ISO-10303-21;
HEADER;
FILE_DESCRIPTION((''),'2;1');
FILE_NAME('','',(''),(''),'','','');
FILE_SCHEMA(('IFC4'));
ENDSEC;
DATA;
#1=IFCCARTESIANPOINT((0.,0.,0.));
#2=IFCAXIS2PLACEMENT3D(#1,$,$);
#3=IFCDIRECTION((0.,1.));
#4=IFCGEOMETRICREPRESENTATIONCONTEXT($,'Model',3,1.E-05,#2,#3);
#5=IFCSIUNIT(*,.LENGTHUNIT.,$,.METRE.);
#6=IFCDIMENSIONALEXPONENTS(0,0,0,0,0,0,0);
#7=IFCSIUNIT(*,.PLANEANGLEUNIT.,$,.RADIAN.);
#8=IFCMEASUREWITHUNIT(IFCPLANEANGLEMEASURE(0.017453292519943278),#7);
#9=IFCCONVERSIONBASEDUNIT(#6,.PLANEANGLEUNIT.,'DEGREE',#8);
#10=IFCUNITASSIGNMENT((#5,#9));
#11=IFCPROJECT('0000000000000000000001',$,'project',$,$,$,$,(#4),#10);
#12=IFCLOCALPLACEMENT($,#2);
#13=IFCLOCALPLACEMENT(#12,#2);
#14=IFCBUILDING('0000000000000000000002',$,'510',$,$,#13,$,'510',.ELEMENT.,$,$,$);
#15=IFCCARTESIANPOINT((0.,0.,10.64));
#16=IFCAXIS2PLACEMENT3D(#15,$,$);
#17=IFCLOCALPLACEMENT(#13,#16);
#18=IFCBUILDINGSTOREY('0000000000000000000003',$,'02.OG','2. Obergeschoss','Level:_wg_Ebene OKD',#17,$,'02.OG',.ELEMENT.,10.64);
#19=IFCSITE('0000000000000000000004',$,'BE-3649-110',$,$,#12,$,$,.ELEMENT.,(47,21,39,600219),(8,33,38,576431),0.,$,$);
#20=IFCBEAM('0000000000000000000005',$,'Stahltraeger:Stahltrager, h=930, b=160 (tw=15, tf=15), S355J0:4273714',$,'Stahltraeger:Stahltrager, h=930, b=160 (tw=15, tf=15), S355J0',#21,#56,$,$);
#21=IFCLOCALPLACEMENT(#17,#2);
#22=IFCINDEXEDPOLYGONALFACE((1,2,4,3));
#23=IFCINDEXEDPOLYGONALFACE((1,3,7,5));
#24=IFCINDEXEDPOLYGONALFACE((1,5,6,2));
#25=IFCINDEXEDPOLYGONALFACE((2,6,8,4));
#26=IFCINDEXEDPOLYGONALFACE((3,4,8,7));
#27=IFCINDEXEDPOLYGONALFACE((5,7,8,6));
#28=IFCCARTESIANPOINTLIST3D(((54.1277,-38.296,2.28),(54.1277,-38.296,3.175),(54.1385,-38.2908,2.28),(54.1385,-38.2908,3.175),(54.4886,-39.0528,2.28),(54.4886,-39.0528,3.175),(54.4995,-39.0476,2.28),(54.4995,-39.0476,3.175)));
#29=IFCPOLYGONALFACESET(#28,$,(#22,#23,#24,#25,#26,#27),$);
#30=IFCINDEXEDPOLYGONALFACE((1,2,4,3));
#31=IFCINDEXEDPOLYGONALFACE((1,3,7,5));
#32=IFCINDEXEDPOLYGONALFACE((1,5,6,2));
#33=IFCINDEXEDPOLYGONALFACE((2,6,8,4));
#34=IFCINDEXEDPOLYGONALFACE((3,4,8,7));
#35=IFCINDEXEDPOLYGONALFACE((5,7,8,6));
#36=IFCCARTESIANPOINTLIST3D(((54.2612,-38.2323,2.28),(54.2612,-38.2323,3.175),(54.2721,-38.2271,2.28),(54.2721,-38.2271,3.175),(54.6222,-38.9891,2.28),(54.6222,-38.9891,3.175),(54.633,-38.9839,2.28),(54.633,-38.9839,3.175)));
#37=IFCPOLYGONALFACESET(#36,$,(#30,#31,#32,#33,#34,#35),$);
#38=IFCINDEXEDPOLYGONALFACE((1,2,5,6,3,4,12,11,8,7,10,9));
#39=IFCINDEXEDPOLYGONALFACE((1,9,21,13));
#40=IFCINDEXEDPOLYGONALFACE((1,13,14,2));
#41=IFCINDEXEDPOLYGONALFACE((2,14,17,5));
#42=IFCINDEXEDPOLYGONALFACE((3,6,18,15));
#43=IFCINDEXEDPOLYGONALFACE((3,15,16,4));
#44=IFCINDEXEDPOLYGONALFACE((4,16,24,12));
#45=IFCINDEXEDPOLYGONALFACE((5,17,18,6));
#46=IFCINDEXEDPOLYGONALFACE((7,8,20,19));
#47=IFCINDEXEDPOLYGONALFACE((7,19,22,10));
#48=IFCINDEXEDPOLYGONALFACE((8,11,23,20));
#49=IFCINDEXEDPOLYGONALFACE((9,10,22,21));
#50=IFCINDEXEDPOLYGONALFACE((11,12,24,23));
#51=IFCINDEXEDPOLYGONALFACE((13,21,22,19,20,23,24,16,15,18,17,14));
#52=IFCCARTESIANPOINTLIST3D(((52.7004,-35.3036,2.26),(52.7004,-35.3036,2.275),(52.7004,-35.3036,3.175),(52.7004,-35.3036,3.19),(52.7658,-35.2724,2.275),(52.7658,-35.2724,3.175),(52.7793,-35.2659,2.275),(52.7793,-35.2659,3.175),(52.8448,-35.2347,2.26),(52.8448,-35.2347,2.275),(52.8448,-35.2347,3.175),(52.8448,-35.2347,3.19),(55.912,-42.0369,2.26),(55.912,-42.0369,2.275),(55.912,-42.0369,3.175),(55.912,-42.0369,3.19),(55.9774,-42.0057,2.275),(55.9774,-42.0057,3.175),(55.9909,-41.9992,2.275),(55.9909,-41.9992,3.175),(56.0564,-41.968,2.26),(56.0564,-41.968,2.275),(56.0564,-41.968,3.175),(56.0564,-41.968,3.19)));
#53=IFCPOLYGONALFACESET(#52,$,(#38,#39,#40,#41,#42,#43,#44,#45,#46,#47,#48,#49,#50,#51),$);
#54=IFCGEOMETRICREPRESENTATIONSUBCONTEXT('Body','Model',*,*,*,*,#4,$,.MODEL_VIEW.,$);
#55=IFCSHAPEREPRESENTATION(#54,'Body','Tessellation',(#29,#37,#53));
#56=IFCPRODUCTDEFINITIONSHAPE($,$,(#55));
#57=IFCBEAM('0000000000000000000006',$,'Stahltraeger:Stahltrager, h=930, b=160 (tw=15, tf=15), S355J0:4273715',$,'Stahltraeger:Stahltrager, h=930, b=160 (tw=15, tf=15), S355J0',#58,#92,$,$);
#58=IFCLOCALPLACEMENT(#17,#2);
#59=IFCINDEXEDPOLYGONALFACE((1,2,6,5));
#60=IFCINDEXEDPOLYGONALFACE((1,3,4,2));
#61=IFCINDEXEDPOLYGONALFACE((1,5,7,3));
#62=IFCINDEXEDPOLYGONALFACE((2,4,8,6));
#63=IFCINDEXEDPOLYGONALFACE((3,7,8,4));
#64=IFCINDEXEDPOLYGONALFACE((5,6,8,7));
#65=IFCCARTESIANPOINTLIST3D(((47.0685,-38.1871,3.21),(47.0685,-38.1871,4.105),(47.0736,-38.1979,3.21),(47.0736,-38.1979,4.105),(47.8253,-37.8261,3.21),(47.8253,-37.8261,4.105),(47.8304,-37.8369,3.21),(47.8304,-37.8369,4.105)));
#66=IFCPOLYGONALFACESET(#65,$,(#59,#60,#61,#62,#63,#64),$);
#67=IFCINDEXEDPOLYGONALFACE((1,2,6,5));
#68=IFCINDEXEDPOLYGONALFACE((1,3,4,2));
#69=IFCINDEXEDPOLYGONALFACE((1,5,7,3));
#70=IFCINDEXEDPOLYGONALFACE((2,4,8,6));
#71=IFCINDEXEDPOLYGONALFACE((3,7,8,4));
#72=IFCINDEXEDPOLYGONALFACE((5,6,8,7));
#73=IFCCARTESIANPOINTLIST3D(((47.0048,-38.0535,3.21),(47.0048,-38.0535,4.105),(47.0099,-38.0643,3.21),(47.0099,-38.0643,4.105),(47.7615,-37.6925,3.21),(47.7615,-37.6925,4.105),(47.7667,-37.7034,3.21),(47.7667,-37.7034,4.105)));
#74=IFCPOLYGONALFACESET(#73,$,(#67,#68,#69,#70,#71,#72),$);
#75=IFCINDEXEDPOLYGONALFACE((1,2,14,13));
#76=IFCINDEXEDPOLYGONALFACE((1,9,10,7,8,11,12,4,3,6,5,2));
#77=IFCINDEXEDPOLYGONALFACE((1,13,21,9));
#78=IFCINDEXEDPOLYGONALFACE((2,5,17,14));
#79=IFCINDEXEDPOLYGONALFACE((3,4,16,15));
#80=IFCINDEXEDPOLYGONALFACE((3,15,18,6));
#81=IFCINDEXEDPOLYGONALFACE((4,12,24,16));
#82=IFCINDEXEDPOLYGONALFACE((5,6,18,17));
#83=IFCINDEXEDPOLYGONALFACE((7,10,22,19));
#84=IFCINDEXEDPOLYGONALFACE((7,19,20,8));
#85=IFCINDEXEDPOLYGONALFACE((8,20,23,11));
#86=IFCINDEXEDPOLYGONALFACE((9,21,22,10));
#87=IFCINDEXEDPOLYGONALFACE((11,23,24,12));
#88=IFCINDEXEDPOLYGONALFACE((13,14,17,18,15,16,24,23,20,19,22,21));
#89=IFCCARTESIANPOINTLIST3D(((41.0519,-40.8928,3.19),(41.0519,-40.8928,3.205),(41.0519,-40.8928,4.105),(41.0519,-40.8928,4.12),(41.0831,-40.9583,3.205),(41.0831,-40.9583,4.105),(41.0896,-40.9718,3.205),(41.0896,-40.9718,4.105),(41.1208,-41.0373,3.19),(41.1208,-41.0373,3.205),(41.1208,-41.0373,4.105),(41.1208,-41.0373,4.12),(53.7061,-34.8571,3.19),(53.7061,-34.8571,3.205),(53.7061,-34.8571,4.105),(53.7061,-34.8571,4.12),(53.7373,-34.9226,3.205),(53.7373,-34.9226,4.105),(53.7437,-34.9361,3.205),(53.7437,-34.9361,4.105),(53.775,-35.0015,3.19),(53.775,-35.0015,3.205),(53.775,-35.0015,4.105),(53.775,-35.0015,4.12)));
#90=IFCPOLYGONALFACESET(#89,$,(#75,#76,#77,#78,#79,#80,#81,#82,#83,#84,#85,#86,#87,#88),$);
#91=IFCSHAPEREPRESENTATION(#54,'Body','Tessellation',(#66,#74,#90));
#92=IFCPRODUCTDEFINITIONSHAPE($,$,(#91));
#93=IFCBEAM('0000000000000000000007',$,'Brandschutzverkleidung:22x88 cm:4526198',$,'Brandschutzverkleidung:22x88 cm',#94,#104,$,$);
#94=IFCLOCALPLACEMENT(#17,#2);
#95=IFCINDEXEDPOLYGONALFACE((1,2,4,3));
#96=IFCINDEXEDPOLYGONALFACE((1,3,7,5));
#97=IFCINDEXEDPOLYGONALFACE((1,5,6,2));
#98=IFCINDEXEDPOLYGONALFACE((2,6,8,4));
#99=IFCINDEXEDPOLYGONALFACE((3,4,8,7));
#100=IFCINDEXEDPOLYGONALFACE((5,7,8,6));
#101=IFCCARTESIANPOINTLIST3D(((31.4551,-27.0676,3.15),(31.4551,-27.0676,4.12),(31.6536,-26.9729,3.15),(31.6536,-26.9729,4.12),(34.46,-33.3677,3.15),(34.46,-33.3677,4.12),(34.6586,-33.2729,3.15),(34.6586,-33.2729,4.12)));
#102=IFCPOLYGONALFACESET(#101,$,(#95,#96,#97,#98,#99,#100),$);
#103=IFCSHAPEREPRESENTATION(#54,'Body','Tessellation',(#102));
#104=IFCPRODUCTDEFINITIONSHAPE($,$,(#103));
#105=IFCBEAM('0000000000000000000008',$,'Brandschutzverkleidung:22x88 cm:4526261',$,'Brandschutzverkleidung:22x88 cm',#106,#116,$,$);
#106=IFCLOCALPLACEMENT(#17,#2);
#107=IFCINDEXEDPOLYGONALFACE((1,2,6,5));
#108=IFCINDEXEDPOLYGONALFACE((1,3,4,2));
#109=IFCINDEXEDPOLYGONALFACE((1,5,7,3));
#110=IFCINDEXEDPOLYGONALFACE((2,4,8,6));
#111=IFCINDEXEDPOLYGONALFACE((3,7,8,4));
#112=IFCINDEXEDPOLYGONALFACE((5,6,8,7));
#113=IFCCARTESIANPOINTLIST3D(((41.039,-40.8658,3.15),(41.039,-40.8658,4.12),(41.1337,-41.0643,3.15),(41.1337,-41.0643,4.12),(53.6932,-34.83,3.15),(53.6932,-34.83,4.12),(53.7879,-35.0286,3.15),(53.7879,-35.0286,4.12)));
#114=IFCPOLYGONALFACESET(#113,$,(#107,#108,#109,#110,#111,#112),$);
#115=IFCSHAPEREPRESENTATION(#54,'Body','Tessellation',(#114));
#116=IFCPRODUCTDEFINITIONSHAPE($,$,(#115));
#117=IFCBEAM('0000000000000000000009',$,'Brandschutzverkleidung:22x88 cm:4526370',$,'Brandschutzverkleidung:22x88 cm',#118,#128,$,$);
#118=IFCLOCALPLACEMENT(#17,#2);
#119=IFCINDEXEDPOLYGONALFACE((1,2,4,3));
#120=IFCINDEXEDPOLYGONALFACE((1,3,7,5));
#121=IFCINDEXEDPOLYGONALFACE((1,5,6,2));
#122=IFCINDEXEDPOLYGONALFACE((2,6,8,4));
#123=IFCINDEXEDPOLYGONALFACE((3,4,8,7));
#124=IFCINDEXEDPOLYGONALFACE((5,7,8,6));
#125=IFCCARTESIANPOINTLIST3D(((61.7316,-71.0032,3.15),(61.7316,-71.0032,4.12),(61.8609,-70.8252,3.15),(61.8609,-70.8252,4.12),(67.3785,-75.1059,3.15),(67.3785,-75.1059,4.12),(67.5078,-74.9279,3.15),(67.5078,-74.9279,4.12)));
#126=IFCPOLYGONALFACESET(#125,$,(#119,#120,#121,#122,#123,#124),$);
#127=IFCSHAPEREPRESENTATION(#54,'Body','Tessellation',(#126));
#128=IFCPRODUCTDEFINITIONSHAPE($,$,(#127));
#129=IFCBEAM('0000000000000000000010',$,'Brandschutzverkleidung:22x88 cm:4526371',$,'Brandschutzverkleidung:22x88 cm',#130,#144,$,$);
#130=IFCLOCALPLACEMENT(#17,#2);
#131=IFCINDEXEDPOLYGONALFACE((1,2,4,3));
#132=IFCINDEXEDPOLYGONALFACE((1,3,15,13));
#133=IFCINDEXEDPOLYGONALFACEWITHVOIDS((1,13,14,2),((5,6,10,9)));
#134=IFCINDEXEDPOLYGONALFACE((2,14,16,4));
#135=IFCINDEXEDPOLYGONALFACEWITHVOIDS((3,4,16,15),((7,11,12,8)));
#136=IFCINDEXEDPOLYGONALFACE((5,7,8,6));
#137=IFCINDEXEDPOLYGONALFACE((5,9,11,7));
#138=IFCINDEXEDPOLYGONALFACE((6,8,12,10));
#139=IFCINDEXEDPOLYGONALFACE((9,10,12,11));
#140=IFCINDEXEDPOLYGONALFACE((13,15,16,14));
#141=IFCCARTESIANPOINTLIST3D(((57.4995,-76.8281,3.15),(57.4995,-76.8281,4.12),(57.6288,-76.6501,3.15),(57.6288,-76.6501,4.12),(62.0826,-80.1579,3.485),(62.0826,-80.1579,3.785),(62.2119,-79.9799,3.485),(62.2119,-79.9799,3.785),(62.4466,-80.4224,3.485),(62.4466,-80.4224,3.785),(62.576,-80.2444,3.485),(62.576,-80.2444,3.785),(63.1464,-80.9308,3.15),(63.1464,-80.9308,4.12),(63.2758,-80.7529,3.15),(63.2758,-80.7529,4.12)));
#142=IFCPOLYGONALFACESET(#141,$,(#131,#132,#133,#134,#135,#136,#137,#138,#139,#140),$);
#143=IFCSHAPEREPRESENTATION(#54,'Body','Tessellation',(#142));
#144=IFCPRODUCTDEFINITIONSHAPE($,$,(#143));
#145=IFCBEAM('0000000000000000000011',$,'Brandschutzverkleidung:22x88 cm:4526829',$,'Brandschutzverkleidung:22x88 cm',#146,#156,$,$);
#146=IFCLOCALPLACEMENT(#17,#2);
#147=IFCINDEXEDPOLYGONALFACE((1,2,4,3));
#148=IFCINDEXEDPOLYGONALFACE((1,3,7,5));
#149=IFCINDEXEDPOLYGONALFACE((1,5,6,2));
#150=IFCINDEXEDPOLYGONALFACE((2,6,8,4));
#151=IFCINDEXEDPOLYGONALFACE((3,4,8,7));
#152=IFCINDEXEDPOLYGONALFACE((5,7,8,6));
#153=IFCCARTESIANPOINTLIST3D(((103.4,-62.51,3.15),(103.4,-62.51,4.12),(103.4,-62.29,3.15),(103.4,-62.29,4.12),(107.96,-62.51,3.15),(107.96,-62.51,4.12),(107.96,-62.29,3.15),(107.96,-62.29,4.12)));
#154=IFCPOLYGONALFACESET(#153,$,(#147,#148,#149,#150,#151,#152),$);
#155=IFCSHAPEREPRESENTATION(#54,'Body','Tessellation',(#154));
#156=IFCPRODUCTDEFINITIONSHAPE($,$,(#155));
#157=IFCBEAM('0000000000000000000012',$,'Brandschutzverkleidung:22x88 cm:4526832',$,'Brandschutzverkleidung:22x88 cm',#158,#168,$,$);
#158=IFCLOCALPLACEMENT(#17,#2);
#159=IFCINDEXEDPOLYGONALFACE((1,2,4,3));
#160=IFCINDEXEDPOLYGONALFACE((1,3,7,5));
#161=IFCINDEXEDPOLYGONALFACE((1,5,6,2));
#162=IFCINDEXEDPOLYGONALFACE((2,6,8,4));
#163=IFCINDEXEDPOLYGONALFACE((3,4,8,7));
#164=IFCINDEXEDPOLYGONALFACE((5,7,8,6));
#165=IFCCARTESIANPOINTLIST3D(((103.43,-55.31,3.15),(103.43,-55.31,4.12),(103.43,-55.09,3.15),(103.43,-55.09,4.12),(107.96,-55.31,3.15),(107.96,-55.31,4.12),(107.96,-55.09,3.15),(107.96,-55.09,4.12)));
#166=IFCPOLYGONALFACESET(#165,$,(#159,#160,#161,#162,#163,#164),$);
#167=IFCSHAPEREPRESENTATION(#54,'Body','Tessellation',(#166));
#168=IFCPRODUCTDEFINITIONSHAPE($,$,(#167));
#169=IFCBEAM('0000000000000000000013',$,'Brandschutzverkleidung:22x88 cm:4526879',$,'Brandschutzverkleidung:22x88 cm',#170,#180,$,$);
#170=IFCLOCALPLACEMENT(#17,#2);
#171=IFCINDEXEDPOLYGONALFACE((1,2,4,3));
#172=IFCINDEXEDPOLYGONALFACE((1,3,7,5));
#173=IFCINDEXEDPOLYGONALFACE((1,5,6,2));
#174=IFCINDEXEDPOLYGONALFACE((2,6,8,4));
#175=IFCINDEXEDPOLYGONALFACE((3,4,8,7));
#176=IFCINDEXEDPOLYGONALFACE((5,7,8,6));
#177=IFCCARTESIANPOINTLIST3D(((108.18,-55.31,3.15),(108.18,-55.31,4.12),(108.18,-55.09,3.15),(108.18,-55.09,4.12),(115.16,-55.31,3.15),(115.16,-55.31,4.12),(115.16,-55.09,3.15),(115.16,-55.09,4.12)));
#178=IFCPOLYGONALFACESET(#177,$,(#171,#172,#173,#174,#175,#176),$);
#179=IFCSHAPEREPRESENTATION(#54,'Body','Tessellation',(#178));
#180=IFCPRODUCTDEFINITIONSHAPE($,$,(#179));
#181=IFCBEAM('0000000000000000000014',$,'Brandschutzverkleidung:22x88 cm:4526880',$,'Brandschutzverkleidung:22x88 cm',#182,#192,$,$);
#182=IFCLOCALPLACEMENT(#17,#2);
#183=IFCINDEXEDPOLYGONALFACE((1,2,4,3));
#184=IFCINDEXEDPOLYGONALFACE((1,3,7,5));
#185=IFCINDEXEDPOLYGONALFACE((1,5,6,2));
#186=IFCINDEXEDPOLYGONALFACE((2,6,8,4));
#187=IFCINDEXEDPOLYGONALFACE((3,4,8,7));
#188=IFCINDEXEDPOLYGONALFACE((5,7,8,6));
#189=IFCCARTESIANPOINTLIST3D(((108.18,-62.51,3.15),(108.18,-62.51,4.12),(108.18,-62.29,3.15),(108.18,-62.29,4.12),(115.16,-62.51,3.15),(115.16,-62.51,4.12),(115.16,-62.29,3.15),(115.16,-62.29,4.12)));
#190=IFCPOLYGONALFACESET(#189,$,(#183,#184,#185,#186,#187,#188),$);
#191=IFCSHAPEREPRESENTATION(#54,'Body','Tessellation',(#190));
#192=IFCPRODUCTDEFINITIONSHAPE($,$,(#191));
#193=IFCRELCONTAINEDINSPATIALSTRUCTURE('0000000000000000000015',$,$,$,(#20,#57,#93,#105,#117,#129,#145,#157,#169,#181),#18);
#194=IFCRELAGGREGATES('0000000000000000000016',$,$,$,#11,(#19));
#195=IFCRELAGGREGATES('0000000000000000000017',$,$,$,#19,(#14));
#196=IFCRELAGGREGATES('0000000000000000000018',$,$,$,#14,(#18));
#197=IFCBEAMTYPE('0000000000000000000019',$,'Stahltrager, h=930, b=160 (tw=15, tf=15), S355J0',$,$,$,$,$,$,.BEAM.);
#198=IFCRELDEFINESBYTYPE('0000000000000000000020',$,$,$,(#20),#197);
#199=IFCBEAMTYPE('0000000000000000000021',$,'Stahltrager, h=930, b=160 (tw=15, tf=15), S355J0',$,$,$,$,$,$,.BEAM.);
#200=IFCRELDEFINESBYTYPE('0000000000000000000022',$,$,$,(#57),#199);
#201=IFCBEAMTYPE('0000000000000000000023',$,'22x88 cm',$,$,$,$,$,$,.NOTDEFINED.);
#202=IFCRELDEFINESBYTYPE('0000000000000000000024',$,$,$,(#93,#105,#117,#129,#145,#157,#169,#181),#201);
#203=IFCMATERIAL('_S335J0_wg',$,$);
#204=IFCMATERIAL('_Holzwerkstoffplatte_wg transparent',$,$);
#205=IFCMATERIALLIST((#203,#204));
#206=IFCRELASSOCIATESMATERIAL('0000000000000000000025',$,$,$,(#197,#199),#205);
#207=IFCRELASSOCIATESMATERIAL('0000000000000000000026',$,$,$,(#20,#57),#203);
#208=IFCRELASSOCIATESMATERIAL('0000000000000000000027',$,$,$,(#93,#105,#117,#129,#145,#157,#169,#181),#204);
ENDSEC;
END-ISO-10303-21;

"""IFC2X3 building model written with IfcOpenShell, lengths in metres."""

from ifc_helpers import new_model, entity, si_unit, converted_unit, direction, frame, frame_2d, origin, origin_2d_with_axis, place, context, subcontext, project, spatial, polyline, rectangle, i_section, outline, extrude, source, transform, mapped, material, material_list, type_object, type_shapes, element, save


model = new_model("IFC2X3")

# Units and contexts
model_context = context("Model", 3, precision=1e-05, world=origin(), true_north=direction((0.0, 1.0)))
body_context = subcontext(model_context, "Body", "Model", "MODEL_VIEW")
ifc_project = project(units=[si_unit("LENGTHUNIT", "METRE"), converted_unit("PLANEANGLEUNIT", "DEGREE", entity("IfcPlaneAngleMeasure", 0.017453292519943278), si_unit("PLANEANGLEUNIT", "RADIAN"), dimensions=[0, 0, 0, 0, 0, 0, 0])], contexts=[model_context])

# Site, building, storey
site_placement = place(None, origin())
site = spatial("IfcSite", under=ifc_project, at=site_placement, Name="BE-3649-110", CompositionType="ELEMENT", RefLatitude=(47, 21, 39, 600219), RefLongitude=(8, 33, 38, 576431), RefElevation=0.0)
building_placement = place(site_placement, origin())
building = spatial("IfcBuilding", under=site, at=building_placement, Name="510", LongName="510", CompositionType="ELEMENT")
storey_placement = place(building_placement, frame((0.0, 0.0, 10.64)))
storey = spatial("IfcBuildingStorey", under=building, at=storey_placement, Name="02.OG", Description="2. Obergeschoss", ObjectType="Level:_wg_Ebene OKD", LongName="02.OG", CompositionType="ELEMENT", Elevation=10.64)

# Beams
ifc_material_1 = material(Name="_S335J0_wg")
ifc_material_2 = material(Name="_Holzwerkstoffplatte_wg transparent")
ifc_material_list = material_list([ifc_material_1, ifc_material_2])
beam_type_1 = type_object("IfcBeamType", Name="Stahltrager, h=930, b=160 (tw=15, tf=15), S355J0", PredefinedType="BEAM", material=ifc_material_list)
shared_shape_1 = source(origin(), body_context, "Body", "SweptSolid", [
    extrude(rectangle(XDim=0.895, YDim=0.012, at=frame_2d((0.0, 0.0), x_axis=(1.0, 0.0))), frame((54.1331, -38.2934, 13.3675), z_axis=(0.430511, -0.902585, 0.0), x_axis=(0.0, 0.0, -1.0)), (0.0, 0.0, 1.0), 0.8385),
    extrude(rectangle(XDim=0.895, YDim=0.012, at=frame_2d((0.0, 0.0), x_axis=(1.0, 0.0))), frame((54.2667, -38.2297, 13.3675), z_axis=(0.430511, -0.902585, 0.0), x_axis=(0.0, 0.0, -1.0)), (0.0, 0.0, 1.0), 0.8385),
    extrude(i_section(OverallWidth=0.16, OverallDepth=0.93, WebThickness=0.015, FlangeThickness=0.015, at=frame_2d((0.0, 0.0), x_axis=(0.0, 1.0))), frame((52.7726, -35.2691, 13.365), z_axis=(0.430511, -0.902585, 0.0), x_axis=(0.0, 0.0, -1.0)), (0.0, 0.0, 1.0), 7.46),
])
type_shapes(beam_type_1, [shared_shape_1])
beam_1_placement = place(storey_placement, frame((0.0, 0.0, -10.64)))
element("IfcBeam", 1, at=beam_1_placement, inside=storey, type_object=beam_type_1, material=ifc_material_1, Name="Stahltraeger:Stahltrager, h=930, b=160 (tw=15, tf=15), S355J0:4273714", ObjectType="Stahltraeger:Stahltrager, h=930, b=160 (tw=15, tf=15), S355J0", context=body_context, shape_type="MappedRepresentation", body=[
    mapped(shared_shape_1, transform((0.0, 0.0, 0.0), scale=1.0)),
])
beam_type_2 = type_object("IfcBeamType", Name="Stahltrager, h=930, b=160 (tw=15, tf=15), S355J0", PredefinedType="BEAM", material=ifc_material_list)
shared_shape_2 = source(origin(), body_context, "Body", "SweptSolid", [
    extrude(rectangle(XDim=0.895, YDim=0.012, at=frame_2d((0.0, 0.0), x_axis=(1.0, 0.0))), frame((47.0711, -38.1925, 14.2975), z_axis=(0.902585, 0.430511, 0.0), x_axis=(0.0, 0.0, 1.0)), (0.0, 0.0, 1.0), 0.8385),
    extrude(rectangle(XDim=0.895, YDim=0.012, at=frame_2d((0.0, 0.0), x_axis=(1.0, 0.0))), frame((47.0073, -38.0589, 14.2975), z_axis=(0.902585, 0.430511, 0.0), x_axis=(0.0, 0.0, 1.0)), (0.0, 0.0, 1.0), 0.8385),
    extrude(outline(polyline([(0.45, -0.08), (0.465, -0.08), (0.465, 0.08), (0.45, 0.08), (0.45, 0.0075), (-0.45, 0.0075), (-0.45, 0.08), (-0.465, 0.08), (-0.465, -0.08), (-0.45, -0.08), (-0.45, -0.0075), (0.45, -0.0075), (0.45, -0.08)])), frame((41.0864, -40.9651, 14.295), z_axis=(0.902585, 0.430511, 0.0), x_axis=(0.0, 0.0, 1.0)), (0.0, 0.0, 1.0), 14.0199),
])
type_shapes(beam_type_2, [shared_shape_2])
beam_2_placement = place(storey_placement, frame((0.0, 0.0, -10.64)))
element("IfcBeam", 2, at=beam_2_placement, inside=storey, type_object=beam_type_2, material=ifc_material_1, Name="Stahltraeger:Stahltrager, h=930, b=160 (tw=15, tf=15), S355J0:4273715", ObjectType="Stahltraeger:Stahltrager, h=930, b=160 (tw=15, tf=15), S355J0", context=body_context, shape_type="MappedRepresentation", body=[
    mapped(shared_shape_2, transform((0.0, 0.0, 0.0), scale=1.0)),
])
beam_type_3 = type_object("IfcBeamType", Name="22x88 cm", PredefinedType="NOTDEFINED")
beam_3_placement = place(storey_placement, frame((0.0, 0.0, 3.635)))
element("IfcBeam", 3, at=beam_3_placement, inside=storey, type_object=beam_type_3, material=ifc_material_2, Name="Brandschutzverkleidung:22x88 cm:4526198", ObjectType="Brandschutzverkleidung:22x88 cm", context=body_context, shape_type="SweptSolid", body=[
    extrude(rectangle(XDim=0.97, YDim=0.22, at=frame_2d((0.0, 0.0), x_axis=(0.0, 1.0))), frame((34.5593, -33.3203, 0.0), z_axis=(-0.430511, 0.902585, 0.0), x_axis=(0.902585, 0.430511, 0.0)), (0.0, 0.0, 1.0), 6.98),
])
beam_4_placement = place(storey_placement, frame((0.0, 0.0, 3.635)))
element("IfcBeam", 4, at=beam_4_placement, inside=storey, type_object=beam_type_3, material=ifc_material_2, Name="Brandschutzverkleidung:22x88 cm:4526261", ObjectType="Brandschutzverkleidung:22x88 cm", context=body_context, shape_type="SweptSolid", body=[
    extrude(rectangle(XDim=0.97, YDim=0.22, at=origin_2d_with_axis()), frame((41.0864, -40.9651, 0.0), z_axis=(0.902585, 0.430511, 0.0), x_axis=(0.0, 0.0, -1.0)), (0.0, 0.0, 1.0), 14.0199),
])
beam_5_placement = place(storey_placement, frame((0.0, 0.0, 3.635)))
element("IfcBeam", 5, at=beam_5_placement, inside=storey, type_object=beam_type_3, material=ifc_material_2, Name="Brandschutzverkleidung:22x88 cm:4526370", ObjectType="Brandschutzverkleidung:22x88 cm", context=body_context, shape_type="SweptSolid", body=[
    extrude(rectangle(XDim=0.97, YDim=0.22, at=frame_2d((0.0, 0.0), x_axis=(1.0, 0.0))), frame((61.7962, -70.9142, 0.0), z_axis=(0.809017, -0.587785, 0.0), x_axis=(0.0, 0.0, -1.0)), (0.0, 0.0, 1.0), 6.98),
])
beam_6_placement = place(storey_placement, frame((0.0, 0.0, 3.635)))
element("IfcBeam", 6, at=beam_6_placement, inside=storey, type_object=beam_type_3, material=ifc_material_2, Name="Brandschutzverkleidung:22x88 cm:4526371", ObjectType="Brandschutzverkleidung:22x88 cm", context=body_context, shape_type="SweptSolid", body=[
    extrude(outline(polyline([(-3.49, -0.485), (3.49, -0.485), (3.49, 0.485), (-3.49, 0.485), (-3.49, -0.485)]), holes=[polyline([(2.175, -0.15), (2.175, 0.15), (2.625, 0.15), (2.625, -0.15), (2.175, -0.15)])]), frame((60.323, -78.8795, 0.0), z_axis=(0.587785, 0.809017, 0.0), x_axis=(0.809017, -0.587785, 0.0)), (0.0, 0.0, 1.0), 0.22),
])
beam_7_placement = place(storey_placement, frame((0.0, 0.0, 3.635)))
element("IfcBeam", 7, at=beam_7_placement, inside=storey, type_object=beam_type_3, material=ifc_material_2, Name="Brandschutzverkleidung:22x88 cm:4526829", ObjectType="Brandschutzverkleidung:22x88 cm", context=body_context, shape_type="SweptSolid", body=[
    extrude(rectangle(XDim=0.97, YDim=0.22, at=origin_2d_with_axis()), frame((103.4, -62.4, 0.0), z_axis=(1.0, 0.0, 0.0), x_axis=(0.0, 0.0, -1.0)), (0.0, 0.0, 1.0), 4.56),
])
beam_8_placement = place(storey_placement, frame((0.0, 0.0, 3.635)))
element("IfcBeam", 8, at=beam_8_placement, inside=storey, type_object=beam_type_3, material=ifc_material_2, Name="Brandschutzverkleidung:22x88 cm:4526832", ObjectType="Brandschutzverkleidung:22x88 cm", context=body_context, shape_type="SweptSolid", body=[
    extrude(rectangle(XDim=0.97, YDim=0.22, at=origin_2d_with_axis()), frame((103.43, -55.2, 0.0), z_axis=(1.0, 0.0, 0.0), x_axis=(0.0, 0.0, -1.0)), (0.0, 0.0, 1.0), 4.53),
])
beam_9_placement = place(storey_placement, frame((0.0, 0.0, 3.635)))
element("IfcBeam", 9, at=beam_9_placement, inside=storey, type_object=beam_type_3, material=ifc_material_2, Name="Brandschutzverkleidung:22x88 cm:4526879", ObjectType="Brandschutzverkleidung:22x88 cm", context=body_context, shape_type="SweptSolid", body=[
    extrude(rectangle(XDim=0.97, YDim=0.22, at=frame_2d((0.0, 0.0), x_axis=(1.0, 0.0))), frame((108.18, -55.2, 0.0), z_axis=(1.0, 0.0, 0.0), x_axis=(0.0, 0.0, -1.0)), (0.0, 0.0, 1.0), 6.98),
])
beam_10_placement = place(storey_placement, frame((0.0, 0.0, 3.635)))
element("IfcBeam", 10, at=beam_10_placement, inside=storey, type_object=beam_type_3, material=ifc_material_2, Name="Brandschutzverkleidung:22x88 cm:4526880", ObjectType="Brandschutzverkleidung:22x88 cm", context=body_context, shape_type="SweptSolid", body=[
    extrude(rectangle(XDim=0.97, YDim=0.22, at=frame_2d((0.0, 0.0), x_axis=(1.0, 0.0))), frame((108.18, -62.4, 0.0), z_axis=(1.0, 0.0, 0.0), x_axis=(0.0, 0.0, -1.0)), (0.0, 0.0, 1.0), 6.98),
])

save(model, "model.ifc")
